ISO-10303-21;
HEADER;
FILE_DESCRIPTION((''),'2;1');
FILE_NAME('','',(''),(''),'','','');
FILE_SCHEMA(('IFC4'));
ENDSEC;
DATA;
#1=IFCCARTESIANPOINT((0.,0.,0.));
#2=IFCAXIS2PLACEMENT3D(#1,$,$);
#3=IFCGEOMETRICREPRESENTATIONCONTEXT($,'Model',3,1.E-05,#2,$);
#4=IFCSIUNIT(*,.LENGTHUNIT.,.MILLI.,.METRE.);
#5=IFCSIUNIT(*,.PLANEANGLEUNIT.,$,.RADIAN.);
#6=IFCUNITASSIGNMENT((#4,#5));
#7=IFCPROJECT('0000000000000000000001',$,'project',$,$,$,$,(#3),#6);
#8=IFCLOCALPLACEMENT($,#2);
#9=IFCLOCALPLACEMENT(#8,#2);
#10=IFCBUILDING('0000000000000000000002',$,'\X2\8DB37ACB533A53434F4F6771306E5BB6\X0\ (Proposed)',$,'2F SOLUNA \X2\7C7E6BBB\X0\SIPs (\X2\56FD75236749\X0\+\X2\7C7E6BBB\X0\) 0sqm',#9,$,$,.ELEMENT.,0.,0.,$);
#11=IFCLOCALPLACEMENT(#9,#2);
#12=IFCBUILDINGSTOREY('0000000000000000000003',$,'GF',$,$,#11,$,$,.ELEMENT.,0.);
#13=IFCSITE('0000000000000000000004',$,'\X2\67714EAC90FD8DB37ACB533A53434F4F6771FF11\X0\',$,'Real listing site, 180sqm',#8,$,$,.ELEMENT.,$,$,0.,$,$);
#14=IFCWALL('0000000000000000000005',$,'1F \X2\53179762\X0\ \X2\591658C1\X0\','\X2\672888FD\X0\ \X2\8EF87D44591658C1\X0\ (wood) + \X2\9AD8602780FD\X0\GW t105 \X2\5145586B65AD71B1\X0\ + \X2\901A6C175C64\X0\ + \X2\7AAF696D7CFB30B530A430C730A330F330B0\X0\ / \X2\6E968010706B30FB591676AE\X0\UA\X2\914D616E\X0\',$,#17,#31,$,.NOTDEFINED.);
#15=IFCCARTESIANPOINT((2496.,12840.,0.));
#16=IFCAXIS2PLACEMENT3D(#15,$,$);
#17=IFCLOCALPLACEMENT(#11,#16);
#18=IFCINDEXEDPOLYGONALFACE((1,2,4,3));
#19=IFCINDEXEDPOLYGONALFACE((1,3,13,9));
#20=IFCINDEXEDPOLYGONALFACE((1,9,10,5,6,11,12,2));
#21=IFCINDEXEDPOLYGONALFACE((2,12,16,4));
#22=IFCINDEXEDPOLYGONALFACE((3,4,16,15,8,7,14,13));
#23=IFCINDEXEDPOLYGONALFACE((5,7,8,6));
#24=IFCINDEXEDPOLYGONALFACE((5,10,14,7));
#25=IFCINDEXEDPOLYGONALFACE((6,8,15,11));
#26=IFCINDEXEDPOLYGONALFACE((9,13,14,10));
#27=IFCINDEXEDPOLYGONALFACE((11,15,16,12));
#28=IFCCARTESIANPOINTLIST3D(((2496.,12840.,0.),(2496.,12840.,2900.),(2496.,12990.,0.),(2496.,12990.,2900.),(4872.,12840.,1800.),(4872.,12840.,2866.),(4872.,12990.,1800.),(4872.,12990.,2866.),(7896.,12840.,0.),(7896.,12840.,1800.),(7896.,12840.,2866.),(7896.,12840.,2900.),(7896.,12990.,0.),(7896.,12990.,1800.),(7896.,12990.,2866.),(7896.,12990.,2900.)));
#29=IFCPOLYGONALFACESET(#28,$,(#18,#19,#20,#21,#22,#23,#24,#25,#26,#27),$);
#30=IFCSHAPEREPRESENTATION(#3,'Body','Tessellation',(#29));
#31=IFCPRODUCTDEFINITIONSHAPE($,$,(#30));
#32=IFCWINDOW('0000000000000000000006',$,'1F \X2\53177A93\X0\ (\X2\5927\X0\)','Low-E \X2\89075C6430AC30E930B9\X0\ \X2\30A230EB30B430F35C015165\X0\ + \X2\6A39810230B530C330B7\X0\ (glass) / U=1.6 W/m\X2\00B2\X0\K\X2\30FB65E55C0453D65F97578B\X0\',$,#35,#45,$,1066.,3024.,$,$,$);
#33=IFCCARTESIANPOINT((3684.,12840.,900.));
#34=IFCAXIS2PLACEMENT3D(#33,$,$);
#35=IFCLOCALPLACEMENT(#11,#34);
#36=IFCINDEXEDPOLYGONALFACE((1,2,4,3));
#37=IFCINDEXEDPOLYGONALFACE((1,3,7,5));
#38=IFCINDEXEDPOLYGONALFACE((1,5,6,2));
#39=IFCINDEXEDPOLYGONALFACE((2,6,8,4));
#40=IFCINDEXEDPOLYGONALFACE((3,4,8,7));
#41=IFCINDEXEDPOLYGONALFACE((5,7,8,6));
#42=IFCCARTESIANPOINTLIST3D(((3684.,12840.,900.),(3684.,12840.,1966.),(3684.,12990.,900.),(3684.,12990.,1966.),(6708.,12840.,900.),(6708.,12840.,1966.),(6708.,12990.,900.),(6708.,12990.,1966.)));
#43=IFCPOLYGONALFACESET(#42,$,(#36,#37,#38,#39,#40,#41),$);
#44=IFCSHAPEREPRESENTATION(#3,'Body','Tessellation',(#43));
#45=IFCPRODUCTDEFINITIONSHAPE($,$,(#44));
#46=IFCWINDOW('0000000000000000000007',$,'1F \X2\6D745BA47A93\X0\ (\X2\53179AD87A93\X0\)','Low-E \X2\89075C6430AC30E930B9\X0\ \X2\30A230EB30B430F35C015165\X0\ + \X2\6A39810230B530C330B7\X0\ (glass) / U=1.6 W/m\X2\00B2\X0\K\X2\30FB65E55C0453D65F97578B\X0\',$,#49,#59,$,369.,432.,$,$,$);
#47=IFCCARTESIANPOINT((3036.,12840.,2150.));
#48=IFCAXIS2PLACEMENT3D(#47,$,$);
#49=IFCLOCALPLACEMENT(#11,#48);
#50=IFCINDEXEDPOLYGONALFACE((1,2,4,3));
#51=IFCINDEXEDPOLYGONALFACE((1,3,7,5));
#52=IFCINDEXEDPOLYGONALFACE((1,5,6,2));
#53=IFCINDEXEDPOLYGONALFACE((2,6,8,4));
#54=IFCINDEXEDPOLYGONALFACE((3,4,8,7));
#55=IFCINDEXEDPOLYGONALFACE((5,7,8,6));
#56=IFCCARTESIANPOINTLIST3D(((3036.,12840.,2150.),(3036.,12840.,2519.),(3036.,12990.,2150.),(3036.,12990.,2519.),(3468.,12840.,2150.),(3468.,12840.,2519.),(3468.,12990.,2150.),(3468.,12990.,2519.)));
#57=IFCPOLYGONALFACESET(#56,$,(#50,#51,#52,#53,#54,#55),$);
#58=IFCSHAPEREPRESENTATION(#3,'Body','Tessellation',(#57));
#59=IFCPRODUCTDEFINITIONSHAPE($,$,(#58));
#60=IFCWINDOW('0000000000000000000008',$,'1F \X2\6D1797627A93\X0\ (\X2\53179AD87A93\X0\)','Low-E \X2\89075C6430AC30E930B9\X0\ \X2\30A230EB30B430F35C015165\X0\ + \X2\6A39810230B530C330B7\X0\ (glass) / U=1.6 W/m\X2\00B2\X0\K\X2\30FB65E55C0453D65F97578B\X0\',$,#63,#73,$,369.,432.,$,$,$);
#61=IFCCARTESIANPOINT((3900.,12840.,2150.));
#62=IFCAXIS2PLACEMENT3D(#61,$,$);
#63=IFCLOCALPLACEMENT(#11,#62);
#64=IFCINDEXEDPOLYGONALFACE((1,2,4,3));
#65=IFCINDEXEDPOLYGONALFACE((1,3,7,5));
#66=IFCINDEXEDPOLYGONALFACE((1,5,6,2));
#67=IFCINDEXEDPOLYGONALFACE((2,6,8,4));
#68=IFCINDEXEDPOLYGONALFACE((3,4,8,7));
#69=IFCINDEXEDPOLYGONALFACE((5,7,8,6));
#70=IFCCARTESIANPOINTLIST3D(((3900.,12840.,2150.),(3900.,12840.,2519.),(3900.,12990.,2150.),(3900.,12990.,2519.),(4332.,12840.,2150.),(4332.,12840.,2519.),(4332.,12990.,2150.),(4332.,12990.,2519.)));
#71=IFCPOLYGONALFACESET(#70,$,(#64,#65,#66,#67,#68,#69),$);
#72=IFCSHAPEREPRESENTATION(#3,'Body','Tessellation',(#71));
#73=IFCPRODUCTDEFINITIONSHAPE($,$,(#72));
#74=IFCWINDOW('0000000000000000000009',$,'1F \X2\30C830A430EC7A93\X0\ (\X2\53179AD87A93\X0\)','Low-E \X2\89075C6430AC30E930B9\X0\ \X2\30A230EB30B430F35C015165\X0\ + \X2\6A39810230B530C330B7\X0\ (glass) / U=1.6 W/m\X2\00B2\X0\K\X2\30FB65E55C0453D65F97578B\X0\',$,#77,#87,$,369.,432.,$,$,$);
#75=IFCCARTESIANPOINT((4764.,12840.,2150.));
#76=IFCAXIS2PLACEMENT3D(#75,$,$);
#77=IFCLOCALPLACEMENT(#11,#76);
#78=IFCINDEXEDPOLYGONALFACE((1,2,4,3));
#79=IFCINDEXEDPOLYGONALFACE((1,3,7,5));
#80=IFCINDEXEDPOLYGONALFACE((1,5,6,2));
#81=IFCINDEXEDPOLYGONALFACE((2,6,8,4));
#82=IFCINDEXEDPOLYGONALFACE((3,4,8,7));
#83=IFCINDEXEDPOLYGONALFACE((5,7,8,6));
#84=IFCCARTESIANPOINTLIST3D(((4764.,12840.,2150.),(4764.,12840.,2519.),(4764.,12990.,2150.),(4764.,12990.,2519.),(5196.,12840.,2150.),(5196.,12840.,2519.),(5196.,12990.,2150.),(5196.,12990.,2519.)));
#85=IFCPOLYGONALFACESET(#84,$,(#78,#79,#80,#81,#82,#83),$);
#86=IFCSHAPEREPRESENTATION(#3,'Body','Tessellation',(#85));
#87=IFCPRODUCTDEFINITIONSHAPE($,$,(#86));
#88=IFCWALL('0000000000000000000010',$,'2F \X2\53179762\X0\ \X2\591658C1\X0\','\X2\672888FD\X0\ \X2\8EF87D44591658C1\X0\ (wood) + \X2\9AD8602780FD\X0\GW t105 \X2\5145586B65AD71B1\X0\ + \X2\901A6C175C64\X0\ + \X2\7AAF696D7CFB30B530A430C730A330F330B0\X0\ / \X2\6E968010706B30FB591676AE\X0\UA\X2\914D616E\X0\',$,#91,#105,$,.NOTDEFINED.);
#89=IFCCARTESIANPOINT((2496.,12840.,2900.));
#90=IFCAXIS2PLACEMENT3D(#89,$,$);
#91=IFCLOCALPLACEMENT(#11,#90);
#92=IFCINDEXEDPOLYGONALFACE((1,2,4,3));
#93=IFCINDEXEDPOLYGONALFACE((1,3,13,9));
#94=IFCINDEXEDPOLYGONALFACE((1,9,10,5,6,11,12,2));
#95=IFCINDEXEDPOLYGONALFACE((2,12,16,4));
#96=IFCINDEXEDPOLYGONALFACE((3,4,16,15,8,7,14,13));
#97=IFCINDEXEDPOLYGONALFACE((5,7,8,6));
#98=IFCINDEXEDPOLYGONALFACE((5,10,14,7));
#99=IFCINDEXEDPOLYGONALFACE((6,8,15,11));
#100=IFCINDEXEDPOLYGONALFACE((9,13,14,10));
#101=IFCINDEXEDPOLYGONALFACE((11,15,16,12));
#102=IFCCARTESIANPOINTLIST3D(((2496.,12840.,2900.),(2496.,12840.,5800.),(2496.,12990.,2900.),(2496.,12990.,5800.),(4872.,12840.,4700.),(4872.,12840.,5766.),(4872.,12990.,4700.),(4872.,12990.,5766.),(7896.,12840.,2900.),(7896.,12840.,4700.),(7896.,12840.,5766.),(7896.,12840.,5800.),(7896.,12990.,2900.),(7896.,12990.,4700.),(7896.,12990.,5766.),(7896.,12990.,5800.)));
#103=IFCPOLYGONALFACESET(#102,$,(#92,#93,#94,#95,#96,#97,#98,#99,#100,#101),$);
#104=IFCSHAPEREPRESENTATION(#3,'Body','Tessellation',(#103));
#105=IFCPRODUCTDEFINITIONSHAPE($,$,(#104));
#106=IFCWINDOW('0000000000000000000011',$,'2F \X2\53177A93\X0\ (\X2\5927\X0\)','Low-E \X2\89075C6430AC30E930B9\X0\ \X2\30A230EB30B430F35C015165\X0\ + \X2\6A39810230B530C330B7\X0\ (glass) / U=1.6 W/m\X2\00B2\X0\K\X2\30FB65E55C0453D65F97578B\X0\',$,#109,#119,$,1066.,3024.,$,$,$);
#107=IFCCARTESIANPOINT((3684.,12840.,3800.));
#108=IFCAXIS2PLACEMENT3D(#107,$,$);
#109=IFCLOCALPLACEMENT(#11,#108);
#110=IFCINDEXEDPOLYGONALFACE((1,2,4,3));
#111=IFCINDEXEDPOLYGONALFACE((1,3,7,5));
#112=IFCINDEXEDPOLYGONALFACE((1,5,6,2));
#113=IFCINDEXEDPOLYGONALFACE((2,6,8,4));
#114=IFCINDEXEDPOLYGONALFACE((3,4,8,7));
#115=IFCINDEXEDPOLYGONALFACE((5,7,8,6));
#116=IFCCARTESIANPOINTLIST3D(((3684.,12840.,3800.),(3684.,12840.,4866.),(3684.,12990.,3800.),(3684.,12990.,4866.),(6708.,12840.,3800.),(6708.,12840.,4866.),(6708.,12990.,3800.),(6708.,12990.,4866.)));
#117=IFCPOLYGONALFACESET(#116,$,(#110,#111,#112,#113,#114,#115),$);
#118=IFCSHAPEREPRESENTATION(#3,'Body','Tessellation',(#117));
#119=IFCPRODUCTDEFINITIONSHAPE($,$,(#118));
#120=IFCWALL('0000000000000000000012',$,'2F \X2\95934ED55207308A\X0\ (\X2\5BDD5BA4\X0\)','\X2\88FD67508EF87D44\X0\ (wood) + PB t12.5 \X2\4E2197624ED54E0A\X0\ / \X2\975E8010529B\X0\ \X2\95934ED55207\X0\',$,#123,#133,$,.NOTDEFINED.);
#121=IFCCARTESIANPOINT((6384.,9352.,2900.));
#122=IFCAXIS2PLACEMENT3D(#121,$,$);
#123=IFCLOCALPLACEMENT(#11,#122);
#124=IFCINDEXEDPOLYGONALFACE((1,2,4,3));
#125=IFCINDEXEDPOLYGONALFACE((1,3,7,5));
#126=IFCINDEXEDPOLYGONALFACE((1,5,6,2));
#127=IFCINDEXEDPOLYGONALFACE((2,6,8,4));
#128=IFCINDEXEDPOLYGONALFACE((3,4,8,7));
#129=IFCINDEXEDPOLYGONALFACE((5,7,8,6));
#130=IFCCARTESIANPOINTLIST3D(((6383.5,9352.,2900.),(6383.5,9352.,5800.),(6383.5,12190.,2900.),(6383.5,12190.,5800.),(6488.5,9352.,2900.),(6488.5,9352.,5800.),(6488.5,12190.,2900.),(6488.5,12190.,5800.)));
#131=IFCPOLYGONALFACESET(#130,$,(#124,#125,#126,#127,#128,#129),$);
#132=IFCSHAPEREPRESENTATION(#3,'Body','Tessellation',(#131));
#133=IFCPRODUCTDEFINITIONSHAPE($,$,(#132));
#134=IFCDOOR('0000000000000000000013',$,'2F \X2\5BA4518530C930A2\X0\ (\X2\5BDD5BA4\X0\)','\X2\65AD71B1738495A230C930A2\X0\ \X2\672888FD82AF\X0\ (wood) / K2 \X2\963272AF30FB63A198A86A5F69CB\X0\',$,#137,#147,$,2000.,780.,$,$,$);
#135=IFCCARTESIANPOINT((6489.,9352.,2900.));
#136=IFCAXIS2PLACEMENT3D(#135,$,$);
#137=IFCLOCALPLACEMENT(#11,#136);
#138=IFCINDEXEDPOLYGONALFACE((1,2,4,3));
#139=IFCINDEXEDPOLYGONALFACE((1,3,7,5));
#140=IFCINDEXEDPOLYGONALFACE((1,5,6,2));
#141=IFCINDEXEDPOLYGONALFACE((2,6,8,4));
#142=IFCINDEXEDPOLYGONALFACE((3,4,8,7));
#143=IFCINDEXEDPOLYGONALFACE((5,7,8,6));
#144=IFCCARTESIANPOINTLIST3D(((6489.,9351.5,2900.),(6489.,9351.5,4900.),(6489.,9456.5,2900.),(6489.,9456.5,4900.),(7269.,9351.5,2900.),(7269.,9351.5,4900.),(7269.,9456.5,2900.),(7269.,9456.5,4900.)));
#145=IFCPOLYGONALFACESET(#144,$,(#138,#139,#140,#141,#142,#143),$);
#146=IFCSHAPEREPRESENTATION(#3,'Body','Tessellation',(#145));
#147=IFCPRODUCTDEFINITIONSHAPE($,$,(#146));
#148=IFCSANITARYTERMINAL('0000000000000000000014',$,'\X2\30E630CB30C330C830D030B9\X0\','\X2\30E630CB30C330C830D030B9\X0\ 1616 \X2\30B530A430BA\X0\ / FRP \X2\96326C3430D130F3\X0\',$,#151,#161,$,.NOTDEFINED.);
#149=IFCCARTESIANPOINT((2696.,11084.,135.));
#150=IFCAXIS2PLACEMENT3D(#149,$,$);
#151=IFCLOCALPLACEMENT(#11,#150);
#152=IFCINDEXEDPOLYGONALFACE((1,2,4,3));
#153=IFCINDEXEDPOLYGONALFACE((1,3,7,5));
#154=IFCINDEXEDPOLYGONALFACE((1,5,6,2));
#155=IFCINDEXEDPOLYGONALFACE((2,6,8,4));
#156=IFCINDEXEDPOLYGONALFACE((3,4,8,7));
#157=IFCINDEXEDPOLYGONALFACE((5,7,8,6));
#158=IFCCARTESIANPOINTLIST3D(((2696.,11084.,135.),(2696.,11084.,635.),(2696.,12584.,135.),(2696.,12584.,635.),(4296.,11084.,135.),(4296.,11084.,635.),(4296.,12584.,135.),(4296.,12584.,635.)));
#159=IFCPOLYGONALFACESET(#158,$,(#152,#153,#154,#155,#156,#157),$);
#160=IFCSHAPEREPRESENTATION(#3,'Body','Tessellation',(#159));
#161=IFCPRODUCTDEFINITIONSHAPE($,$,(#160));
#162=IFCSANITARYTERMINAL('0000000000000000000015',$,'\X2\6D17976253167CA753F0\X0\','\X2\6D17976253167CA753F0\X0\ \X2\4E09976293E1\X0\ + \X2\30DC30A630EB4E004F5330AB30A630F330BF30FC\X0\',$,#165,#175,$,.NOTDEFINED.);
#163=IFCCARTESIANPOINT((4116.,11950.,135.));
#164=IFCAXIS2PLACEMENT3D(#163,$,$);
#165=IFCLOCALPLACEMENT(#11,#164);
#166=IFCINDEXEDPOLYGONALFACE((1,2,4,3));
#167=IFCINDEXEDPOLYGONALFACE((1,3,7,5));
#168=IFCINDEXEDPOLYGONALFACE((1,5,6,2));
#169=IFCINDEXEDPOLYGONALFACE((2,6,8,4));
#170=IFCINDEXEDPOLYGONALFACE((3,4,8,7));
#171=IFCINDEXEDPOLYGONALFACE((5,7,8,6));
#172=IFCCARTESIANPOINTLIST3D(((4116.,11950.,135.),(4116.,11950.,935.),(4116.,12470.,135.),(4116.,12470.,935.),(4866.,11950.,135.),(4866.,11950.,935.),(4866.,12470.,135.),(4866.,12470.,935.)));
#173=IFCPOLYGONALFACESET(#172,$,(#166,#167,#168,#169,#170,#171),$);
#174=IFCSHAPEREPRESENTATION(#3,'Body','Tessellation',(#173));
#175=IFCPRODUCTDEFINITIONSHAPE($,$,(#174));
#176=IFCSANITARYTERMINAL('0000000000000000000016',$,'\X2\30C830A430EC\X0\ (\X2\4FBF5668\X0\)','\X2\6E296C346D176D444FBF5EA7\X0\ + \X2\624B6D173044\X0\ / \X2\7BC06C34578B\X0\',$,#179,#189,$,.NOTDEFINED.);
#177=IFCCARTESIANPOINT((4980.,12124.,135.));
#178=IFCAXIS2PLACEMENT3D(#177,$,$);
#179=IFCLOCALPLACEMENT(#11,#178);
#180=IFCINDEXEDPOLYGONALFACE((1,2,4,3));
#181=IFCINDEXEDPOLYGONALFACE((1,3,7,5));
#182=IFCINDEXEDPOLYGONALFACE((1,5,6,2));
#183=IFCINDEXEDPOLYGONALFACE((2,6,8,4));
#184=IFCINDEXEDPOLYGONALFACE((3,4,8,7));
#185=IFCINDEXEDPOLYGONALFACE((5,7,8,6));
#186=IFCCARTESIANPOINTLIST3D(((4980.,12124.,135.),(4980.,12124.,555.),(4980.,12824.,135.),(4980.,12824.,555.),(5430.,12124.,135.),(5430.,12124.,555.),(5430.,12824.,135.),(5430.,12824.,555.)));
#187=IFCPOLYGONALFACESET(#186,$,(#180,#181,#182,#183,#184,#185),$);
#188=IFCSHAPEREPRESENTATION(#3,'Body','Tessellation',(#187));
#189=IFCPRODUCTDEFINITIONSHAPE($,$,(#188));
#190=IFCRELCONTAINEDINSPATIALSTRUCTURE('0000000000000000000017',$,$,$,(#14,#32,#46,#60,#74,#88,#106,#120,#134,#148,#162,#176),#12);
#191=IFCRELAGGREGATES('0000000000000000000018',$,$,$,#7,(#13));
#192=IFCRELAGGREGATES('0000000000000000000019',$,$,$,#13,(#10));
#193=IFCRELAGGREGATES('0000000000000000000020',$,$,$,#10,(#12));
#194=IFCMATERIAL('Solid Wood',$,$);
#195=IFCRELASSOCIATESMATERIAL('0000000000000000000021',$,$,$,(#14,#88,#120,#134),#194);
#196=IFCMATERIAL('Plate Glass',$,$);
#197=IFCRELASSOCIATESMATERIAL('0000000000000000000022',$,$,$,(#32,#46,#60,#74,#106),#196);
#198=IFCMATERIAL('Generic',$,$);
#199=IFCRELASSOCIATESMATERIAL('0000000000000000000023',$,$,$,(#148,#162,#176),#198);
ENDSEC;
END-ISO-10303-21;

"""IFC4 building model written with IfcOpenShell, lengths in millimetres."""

from ifc_helpers import new_model, si_unit, frame, frame_2d, origin, place, context, project, spatial, rectangle, extrude, material, element, fill, save


model = new_model("IFC4")

# Units and contexts
model_context = context("Model", 3, precision=1e-05, world=origin())
ifc_project = project(units=[si_unit("LENGTHUNIT", "METRE", prefix="MILLI"), si_unit("PLANEANGLEUNIT", "RADIAN")], contexts=[model_context])

# Site, building, storey
site_placement = place(None, origin())
site = spatial("IfcSite", under=ifc_project, at=site_placement, Name="東京都足立区千住東１", ObjectType="Real listing site, 180sqm", CompositionType="ELEMENT", RefElevation=0.0)
building_placement = place(site_placement, origin())
building = spatial("IfcBuilding", under=site, at=building_placement, Name="足立区千住東の家 (Proposed)", ObjectType="2F SOLUNA 籾殻SIPs (国産杉+籾殻) 0sqm", CompositionType="ELEMENT", ElevationOfRefHeight=0.0, ElevationOfTerrain=0.0)
storey_placement = place(building_placement, origin())
storey = spatial("IfcBuildingStorey", under=building, at=storey_placement, Name="GF", CompositionType="ELEMENT", Elevation=0.0)

# Wall, openings, windows
ifc_material_1 = material(Name="Solid Wood")
wall_1_placement = place(storey_placement, frame((2496.0, 12840.0, 0.0)))
wall_1 = element("IfcWall", 1, at=wall_1_placement, inside=storey, material=ifc_material_1, Name="1F 北面 外壁", Description="木製 軸組外壁 (wood) + 高性能GW t105 充填断熱 + 通気層 + 窯業系サイディング / 準耐火・外皮UA配慮", PredefinedType="NOTDEFINED", context=model_context, shape_type="SweptSolid", body=[
    extrude(rectangle(XDim=5400.0, YDim=150.0, at=frame_2d((2700.0, 75.0))), frame((2496.0, 12840.0, 0.0)), (0.0, 0.0, 1.0), 2900.0),
])
opening_1_placement = place(storey_placement, frame((3684.0, 12840.0, 900.0)))
opening_1 = element("IfcOpeningElement", 2, at=opening_1_placement, cuts=wall_1, PredefinedType="NOTDEFINED", context=model_context, shape_type="SweptSolid", body=[
    extrude(rectangle(XDim=3024.0, YDim=150.0, at=frame_2d((1512.0, 75.0))), frame((3684.0, 12840.0, 900.0)), (0.0, 0.0, 1.0), 1066.0),
])
opening_2_placement = place(storey_placement, frame((3036.0, 12840.0, 2150.0)))
opening_2 = element("IfcOpeningElement", 3, at=opening_2_placement, cuts=wall_1, PredefinedType="NOTDEFINED", context=model_context, shape_type="SweptSolid", body=[
    extrude(rectangle(XDim=432.0, YDim=150.0, at=frame_2d((216.0, 75.0))), frame((3036.0, 12840.0, 2150.0)), (0.0, 0.0, 1.0), 369.0),
])
opening_3_placement = place(storey_placement, frame((3900.0, 12840.0, 2150.0)))
opening_3 = element("IfcOpeningElement", 4, at=opening_3_placement, cuts=wall_1, PredefinedType="NOTDEFINED", context=model_context, shape_type="SweptSolid", body=[
    extrude(rectangle(XDim=432.0, YDim=150.0, at=frame_2d((216.0, 75.0))), frame((3900.0, 12840.0, 2150.0)), (0.0, 0.0, 1.0), 369.0),
])
opening_4_placement = place(storey_placement, frame((4764.0, 12840.0, 2150.0)))
opening_4 = element("IfcOpeningElement", 5, at=opening_4_placement, cuts=wall_1, PredefinedType="NOTDEFINED", context=model_context, shape_type="SweptSolid", body=[
    extrude(rectangle(XDim=432.0, YDim=150.0, at=frame_2d((216.0, 75.0))), frame((4764.0, 12840.0, 2150.0)), (0.0, 0.0, 1.0), 369.0),
])
ifc_material_2 = material(Name="Plate Glass")
window_1_placement = place(storey_placement, frame((3684.0, 12840.0, 900.0)))
window_1 = element("IfcWindow", 6, at=window_1_placement, inside=storey, material=ifc_material_2, Name="1F 北窓 (大)", Description="Low-E 複層ガラス アルゴン封入 + 樹脂サッシ (glass) / U=1.6 W/m²K・日射取得型", OverallHeight=1066.0, OverallWidth=3024.0, context=model_context, shape_type="SweptSolid", body=[
    extrude(rectangle(XDim=3024.0, YDim=150.0, at=frame_2d((1512.0, 75.0))), frame((3684.0, 12840.0, 900.0)), (0.0, 0.0, 1.0), 1066.0),
])
fill(opening_1, window_1)
window_2_placement = place(storey_placement, frame((3036.0, 12840.0, 2150.0)))
window_2 = element("IfcWindow", 7, at=window_2_placement, inside=storey, material=ifc_material_2, Name="1F 浴室窓 (北高窓)", Description="Low-E 複層ガラス アルゴン封入 + 樹脂サッシ (glass) / U=1.6 W/m²K・日射取得型", OverallHeight=369.0, OverallWidth=432.0, context=model_context, shape_type="SweptSolid", body=[
    extrude(rectangle(XDim=432.0, YDim=150.0, at=frame_2d((216.0, 75.0))), frame((3036.0, 12840.0, 2150.0)), (0.0, 0.0, 1.0), 369.0),
])
fill(opening_2, window_2)
window_3_placement = place(storey_placement, frame((3900.0, 12840.0, 2150.0)))
window_3 = element("IfcWindow", 8, at=window_3_placement, inside=storey, material=ifc_material_2, Name="1F 洗面窓 (北高窓)", Description="Low-E 複層ガラス アルゴン封入 + 樹脂サッシ (glass) / U=1.6 W/m²K・日射取得型", OverallHeight=369.0, OverallWidth=432.0, context=model_context, shape_type="SweptSolid", body=[
    extrude(rectangle(XDim=432.0, YDim=150.0, at=frame_2d((216.0, 75.0))), frame((3900.0, 12840.0, 2150.0)), (0.0, 0.0, 1.0), 369.0),
])
fill(opening_3, window_3)
window_4_placement = place(storey_placement, frame((4764.0, 12840.0, 2150.0)))
window_4 = element("IfcWindow", 9, at=window_4_placement, inside=storey, material=ifc_material_2, Name="1F トイレ窓 (北高窓)", Description="Low-E 複層ガラス アルゴン封入 + 樹脂サッシ (glass) / U=1.6 W/m²K・日射取得型", OverallHeight=369.0, OverallWidth=432.0, context=model_context, shape_type="SweptSolid", body=[
    extrude(rectangle(XDim=432.0, YDim=150.0, at=frame_2d((216.0, 75.0))), frame((4764.0, 12840.0, 2150.0)), (0.0, 0.0, 1.0), 369.0),
])
fill(opening_4, window_4)

# Wall, opening, window
wall_2_placement = place(storey_placement, frame((2496.0, 12840.0, 2900.0)))
wall_2 = element("IfcWall", 10, at=wall_2_placement, inside=storey, material=ifc_material_1, Name="2F 北面 外壁", Description="木製 軸組外壁 (wood) + 高性能GW t105 充填断熱 + 通気層 + 窯業系サイディング / 準耐火・外皮UA配慮", PredefinedType="NOTDEFINED", context=model_context, shape_type="SweptSolid", body=[
    extrude(rectangle(XDim=5400.0, YDim=150.0, at=frame_2d((2700.0, 75.0))), frame((2496.0, 12840.0, 2900.0)), (0.0, 0.0, 1.0), 2900.0),
])
opening_5_placement = place(storey_placement, frame((3684.0, 12840.0, 3800.0)))
opening_5 = element("IfcOpeningElement", 11, at=opening_5_placement, cuts=wall_2, PredefinedType="NOTDEFINED", context=model_context, shape_type="SweptSolid", body=[
    extrude(rectangle(XDim=3024.0, YDim=150.0, at=frame_2d((1512.0, 75.0))), frame((3684.0, 12840.0, 3800.0)), (0.0, 0.0, 1.0), 1066.0),
])
window_5_placement = place(storey_placement, frame((3684.0, 12840.0, 3800.0)))
window_5 = element("IfcWindow", 12, at=window_5_placement, inside=storey, material=ifc_material_2, Name="2F 北窓 (大)", Description="Low-E 複層ガラス アルゴン封入 + 樹脂サッシ (glass) / U=1.6 W/m²K・日射取得型", OverallHeight=1066.0, OverallWidth=3024.0, context=model_context, shape_type="SweptSolid", body=[
    extrude(rectangle(XDim=3024.0, YDim=150.0, at=frame_2d((1512.0, 75.0))), frame((3684.0, 12840.0, 3800.0)), (0.0, 0.0, 1.0), 1066.0),
])
fill(opening_5, window_5)

# Wall
wall_3_placement = place(storey_placement, frame((6384.0, 9352.0, 2900.0)))
element("IfcWall", 13, at=wall_3_placement, inside=storey, material=ifc_material_1, Name="2F 間仕切り (寝室)", Description="製材軸組 (wood) + PB t12.5 両面仕上 / 非耐力 間仕切", PredefinedType="NOTDEFINED", context=model_context, shape_type="SweptSolid", body=[
    extrude(rectangle(XDim=105.0, YDim=2838.0, at=frame_2d((52.0, 1419.0))), frame((6384.0, 9352.0, 2900.0)), (0.0, 0.0, 1.0), 2900.0),
])

# Door
door_1_placement = place(storey_placement, frame((6489.0, 9352.0, 2900.0)))
element("IfcDoor", 14, at=door_1_placement, inside=storey, material=ifc_material_1, Name="2F 室内ドア (寝室)", Description="断熱玄関ドア 木製芯 (wood) / K2 防犯・採風機構", OverallHeight=2000.0, OverallWidth=780.0, context=model_context, shape_type="SweptSolid", body=[
    extrude(rectangle(XDim=780.0, YDim=105.0, at=frame_2d((390.0, 52.0))), frame((6489.0, 9352.0, 2900.0)), (0.0, 0.0, 1.0), 2000.0),
])

# Sanitary terminals
ifc_material_3 = material(Name="Generic")
sanitary_terminal_1_placement = place(storey_placement, frame((2696.0, 11084.0, 135.0)))
element("IfcSanitaryTerminal", 15, at=sanitary_terminal_1_placement, inside=storey, material=ifc_material_3, Name="ユニットバス", Description="ユニットバス 1616 サイズ / FRP 防水パン", PredefinedType="NOTDEFINED", context=model_context, shape_type="SweptSolid", body=[
    extrude(rectangle(XDim=1600.0, YDim=1500.0, at=frame_2d((800.0, 750.0))), frame((2696.0, 11084.0, 135.0)), (0.0, 0.0, 1.0), 500.0),
])
sanitary_terminal_2_placement = place(storey_placement, frame((4116.0, 11950.0, 135.0)))
element("IfcSanitaryTerminal", 16, at=sanitary_terminal_2_placement, inside=storey, material=ifc_material_3, Name="洗面化粧台", Description="洗面化粧台 三面鏡 + ボウル一体カウンター", PredefinedType="NOTDEFINED", context=model_context, shape_type="SweptSolid", body=[
    extrude(rectangle(XDim=750.0, YDim=520.0, at=frame_2d((375.0, 260.0))), frame((4116.0, 11950.0, 135.0)), (0.0, 0.0, 1.0), 800.0),
])
sanitary_terminal_3_placement = place(storey_placement, frame((4980.0, 12124.0, 135.0)))
element("IfcSanitaryTerminal", 17, at=sanitary_terminal_3_placement, inside=storey, material=ifc_material_3, Name="トイレ (便器)", Description="温水洗浄便座 + 手洗い / 節水型", PredefinedType="NOTDEFINED", context=model_context, shape_type="SweptSolid", body=[
    extrude(rectangle(XDim=450.0, YDim=700.0, at=frame_2d((225.0, 350.0))), frame((4980.0, 12124.0, 135.0)), (0.0, 0.0, 1.0), 420.0),
])

save(model, "model.ifc")
